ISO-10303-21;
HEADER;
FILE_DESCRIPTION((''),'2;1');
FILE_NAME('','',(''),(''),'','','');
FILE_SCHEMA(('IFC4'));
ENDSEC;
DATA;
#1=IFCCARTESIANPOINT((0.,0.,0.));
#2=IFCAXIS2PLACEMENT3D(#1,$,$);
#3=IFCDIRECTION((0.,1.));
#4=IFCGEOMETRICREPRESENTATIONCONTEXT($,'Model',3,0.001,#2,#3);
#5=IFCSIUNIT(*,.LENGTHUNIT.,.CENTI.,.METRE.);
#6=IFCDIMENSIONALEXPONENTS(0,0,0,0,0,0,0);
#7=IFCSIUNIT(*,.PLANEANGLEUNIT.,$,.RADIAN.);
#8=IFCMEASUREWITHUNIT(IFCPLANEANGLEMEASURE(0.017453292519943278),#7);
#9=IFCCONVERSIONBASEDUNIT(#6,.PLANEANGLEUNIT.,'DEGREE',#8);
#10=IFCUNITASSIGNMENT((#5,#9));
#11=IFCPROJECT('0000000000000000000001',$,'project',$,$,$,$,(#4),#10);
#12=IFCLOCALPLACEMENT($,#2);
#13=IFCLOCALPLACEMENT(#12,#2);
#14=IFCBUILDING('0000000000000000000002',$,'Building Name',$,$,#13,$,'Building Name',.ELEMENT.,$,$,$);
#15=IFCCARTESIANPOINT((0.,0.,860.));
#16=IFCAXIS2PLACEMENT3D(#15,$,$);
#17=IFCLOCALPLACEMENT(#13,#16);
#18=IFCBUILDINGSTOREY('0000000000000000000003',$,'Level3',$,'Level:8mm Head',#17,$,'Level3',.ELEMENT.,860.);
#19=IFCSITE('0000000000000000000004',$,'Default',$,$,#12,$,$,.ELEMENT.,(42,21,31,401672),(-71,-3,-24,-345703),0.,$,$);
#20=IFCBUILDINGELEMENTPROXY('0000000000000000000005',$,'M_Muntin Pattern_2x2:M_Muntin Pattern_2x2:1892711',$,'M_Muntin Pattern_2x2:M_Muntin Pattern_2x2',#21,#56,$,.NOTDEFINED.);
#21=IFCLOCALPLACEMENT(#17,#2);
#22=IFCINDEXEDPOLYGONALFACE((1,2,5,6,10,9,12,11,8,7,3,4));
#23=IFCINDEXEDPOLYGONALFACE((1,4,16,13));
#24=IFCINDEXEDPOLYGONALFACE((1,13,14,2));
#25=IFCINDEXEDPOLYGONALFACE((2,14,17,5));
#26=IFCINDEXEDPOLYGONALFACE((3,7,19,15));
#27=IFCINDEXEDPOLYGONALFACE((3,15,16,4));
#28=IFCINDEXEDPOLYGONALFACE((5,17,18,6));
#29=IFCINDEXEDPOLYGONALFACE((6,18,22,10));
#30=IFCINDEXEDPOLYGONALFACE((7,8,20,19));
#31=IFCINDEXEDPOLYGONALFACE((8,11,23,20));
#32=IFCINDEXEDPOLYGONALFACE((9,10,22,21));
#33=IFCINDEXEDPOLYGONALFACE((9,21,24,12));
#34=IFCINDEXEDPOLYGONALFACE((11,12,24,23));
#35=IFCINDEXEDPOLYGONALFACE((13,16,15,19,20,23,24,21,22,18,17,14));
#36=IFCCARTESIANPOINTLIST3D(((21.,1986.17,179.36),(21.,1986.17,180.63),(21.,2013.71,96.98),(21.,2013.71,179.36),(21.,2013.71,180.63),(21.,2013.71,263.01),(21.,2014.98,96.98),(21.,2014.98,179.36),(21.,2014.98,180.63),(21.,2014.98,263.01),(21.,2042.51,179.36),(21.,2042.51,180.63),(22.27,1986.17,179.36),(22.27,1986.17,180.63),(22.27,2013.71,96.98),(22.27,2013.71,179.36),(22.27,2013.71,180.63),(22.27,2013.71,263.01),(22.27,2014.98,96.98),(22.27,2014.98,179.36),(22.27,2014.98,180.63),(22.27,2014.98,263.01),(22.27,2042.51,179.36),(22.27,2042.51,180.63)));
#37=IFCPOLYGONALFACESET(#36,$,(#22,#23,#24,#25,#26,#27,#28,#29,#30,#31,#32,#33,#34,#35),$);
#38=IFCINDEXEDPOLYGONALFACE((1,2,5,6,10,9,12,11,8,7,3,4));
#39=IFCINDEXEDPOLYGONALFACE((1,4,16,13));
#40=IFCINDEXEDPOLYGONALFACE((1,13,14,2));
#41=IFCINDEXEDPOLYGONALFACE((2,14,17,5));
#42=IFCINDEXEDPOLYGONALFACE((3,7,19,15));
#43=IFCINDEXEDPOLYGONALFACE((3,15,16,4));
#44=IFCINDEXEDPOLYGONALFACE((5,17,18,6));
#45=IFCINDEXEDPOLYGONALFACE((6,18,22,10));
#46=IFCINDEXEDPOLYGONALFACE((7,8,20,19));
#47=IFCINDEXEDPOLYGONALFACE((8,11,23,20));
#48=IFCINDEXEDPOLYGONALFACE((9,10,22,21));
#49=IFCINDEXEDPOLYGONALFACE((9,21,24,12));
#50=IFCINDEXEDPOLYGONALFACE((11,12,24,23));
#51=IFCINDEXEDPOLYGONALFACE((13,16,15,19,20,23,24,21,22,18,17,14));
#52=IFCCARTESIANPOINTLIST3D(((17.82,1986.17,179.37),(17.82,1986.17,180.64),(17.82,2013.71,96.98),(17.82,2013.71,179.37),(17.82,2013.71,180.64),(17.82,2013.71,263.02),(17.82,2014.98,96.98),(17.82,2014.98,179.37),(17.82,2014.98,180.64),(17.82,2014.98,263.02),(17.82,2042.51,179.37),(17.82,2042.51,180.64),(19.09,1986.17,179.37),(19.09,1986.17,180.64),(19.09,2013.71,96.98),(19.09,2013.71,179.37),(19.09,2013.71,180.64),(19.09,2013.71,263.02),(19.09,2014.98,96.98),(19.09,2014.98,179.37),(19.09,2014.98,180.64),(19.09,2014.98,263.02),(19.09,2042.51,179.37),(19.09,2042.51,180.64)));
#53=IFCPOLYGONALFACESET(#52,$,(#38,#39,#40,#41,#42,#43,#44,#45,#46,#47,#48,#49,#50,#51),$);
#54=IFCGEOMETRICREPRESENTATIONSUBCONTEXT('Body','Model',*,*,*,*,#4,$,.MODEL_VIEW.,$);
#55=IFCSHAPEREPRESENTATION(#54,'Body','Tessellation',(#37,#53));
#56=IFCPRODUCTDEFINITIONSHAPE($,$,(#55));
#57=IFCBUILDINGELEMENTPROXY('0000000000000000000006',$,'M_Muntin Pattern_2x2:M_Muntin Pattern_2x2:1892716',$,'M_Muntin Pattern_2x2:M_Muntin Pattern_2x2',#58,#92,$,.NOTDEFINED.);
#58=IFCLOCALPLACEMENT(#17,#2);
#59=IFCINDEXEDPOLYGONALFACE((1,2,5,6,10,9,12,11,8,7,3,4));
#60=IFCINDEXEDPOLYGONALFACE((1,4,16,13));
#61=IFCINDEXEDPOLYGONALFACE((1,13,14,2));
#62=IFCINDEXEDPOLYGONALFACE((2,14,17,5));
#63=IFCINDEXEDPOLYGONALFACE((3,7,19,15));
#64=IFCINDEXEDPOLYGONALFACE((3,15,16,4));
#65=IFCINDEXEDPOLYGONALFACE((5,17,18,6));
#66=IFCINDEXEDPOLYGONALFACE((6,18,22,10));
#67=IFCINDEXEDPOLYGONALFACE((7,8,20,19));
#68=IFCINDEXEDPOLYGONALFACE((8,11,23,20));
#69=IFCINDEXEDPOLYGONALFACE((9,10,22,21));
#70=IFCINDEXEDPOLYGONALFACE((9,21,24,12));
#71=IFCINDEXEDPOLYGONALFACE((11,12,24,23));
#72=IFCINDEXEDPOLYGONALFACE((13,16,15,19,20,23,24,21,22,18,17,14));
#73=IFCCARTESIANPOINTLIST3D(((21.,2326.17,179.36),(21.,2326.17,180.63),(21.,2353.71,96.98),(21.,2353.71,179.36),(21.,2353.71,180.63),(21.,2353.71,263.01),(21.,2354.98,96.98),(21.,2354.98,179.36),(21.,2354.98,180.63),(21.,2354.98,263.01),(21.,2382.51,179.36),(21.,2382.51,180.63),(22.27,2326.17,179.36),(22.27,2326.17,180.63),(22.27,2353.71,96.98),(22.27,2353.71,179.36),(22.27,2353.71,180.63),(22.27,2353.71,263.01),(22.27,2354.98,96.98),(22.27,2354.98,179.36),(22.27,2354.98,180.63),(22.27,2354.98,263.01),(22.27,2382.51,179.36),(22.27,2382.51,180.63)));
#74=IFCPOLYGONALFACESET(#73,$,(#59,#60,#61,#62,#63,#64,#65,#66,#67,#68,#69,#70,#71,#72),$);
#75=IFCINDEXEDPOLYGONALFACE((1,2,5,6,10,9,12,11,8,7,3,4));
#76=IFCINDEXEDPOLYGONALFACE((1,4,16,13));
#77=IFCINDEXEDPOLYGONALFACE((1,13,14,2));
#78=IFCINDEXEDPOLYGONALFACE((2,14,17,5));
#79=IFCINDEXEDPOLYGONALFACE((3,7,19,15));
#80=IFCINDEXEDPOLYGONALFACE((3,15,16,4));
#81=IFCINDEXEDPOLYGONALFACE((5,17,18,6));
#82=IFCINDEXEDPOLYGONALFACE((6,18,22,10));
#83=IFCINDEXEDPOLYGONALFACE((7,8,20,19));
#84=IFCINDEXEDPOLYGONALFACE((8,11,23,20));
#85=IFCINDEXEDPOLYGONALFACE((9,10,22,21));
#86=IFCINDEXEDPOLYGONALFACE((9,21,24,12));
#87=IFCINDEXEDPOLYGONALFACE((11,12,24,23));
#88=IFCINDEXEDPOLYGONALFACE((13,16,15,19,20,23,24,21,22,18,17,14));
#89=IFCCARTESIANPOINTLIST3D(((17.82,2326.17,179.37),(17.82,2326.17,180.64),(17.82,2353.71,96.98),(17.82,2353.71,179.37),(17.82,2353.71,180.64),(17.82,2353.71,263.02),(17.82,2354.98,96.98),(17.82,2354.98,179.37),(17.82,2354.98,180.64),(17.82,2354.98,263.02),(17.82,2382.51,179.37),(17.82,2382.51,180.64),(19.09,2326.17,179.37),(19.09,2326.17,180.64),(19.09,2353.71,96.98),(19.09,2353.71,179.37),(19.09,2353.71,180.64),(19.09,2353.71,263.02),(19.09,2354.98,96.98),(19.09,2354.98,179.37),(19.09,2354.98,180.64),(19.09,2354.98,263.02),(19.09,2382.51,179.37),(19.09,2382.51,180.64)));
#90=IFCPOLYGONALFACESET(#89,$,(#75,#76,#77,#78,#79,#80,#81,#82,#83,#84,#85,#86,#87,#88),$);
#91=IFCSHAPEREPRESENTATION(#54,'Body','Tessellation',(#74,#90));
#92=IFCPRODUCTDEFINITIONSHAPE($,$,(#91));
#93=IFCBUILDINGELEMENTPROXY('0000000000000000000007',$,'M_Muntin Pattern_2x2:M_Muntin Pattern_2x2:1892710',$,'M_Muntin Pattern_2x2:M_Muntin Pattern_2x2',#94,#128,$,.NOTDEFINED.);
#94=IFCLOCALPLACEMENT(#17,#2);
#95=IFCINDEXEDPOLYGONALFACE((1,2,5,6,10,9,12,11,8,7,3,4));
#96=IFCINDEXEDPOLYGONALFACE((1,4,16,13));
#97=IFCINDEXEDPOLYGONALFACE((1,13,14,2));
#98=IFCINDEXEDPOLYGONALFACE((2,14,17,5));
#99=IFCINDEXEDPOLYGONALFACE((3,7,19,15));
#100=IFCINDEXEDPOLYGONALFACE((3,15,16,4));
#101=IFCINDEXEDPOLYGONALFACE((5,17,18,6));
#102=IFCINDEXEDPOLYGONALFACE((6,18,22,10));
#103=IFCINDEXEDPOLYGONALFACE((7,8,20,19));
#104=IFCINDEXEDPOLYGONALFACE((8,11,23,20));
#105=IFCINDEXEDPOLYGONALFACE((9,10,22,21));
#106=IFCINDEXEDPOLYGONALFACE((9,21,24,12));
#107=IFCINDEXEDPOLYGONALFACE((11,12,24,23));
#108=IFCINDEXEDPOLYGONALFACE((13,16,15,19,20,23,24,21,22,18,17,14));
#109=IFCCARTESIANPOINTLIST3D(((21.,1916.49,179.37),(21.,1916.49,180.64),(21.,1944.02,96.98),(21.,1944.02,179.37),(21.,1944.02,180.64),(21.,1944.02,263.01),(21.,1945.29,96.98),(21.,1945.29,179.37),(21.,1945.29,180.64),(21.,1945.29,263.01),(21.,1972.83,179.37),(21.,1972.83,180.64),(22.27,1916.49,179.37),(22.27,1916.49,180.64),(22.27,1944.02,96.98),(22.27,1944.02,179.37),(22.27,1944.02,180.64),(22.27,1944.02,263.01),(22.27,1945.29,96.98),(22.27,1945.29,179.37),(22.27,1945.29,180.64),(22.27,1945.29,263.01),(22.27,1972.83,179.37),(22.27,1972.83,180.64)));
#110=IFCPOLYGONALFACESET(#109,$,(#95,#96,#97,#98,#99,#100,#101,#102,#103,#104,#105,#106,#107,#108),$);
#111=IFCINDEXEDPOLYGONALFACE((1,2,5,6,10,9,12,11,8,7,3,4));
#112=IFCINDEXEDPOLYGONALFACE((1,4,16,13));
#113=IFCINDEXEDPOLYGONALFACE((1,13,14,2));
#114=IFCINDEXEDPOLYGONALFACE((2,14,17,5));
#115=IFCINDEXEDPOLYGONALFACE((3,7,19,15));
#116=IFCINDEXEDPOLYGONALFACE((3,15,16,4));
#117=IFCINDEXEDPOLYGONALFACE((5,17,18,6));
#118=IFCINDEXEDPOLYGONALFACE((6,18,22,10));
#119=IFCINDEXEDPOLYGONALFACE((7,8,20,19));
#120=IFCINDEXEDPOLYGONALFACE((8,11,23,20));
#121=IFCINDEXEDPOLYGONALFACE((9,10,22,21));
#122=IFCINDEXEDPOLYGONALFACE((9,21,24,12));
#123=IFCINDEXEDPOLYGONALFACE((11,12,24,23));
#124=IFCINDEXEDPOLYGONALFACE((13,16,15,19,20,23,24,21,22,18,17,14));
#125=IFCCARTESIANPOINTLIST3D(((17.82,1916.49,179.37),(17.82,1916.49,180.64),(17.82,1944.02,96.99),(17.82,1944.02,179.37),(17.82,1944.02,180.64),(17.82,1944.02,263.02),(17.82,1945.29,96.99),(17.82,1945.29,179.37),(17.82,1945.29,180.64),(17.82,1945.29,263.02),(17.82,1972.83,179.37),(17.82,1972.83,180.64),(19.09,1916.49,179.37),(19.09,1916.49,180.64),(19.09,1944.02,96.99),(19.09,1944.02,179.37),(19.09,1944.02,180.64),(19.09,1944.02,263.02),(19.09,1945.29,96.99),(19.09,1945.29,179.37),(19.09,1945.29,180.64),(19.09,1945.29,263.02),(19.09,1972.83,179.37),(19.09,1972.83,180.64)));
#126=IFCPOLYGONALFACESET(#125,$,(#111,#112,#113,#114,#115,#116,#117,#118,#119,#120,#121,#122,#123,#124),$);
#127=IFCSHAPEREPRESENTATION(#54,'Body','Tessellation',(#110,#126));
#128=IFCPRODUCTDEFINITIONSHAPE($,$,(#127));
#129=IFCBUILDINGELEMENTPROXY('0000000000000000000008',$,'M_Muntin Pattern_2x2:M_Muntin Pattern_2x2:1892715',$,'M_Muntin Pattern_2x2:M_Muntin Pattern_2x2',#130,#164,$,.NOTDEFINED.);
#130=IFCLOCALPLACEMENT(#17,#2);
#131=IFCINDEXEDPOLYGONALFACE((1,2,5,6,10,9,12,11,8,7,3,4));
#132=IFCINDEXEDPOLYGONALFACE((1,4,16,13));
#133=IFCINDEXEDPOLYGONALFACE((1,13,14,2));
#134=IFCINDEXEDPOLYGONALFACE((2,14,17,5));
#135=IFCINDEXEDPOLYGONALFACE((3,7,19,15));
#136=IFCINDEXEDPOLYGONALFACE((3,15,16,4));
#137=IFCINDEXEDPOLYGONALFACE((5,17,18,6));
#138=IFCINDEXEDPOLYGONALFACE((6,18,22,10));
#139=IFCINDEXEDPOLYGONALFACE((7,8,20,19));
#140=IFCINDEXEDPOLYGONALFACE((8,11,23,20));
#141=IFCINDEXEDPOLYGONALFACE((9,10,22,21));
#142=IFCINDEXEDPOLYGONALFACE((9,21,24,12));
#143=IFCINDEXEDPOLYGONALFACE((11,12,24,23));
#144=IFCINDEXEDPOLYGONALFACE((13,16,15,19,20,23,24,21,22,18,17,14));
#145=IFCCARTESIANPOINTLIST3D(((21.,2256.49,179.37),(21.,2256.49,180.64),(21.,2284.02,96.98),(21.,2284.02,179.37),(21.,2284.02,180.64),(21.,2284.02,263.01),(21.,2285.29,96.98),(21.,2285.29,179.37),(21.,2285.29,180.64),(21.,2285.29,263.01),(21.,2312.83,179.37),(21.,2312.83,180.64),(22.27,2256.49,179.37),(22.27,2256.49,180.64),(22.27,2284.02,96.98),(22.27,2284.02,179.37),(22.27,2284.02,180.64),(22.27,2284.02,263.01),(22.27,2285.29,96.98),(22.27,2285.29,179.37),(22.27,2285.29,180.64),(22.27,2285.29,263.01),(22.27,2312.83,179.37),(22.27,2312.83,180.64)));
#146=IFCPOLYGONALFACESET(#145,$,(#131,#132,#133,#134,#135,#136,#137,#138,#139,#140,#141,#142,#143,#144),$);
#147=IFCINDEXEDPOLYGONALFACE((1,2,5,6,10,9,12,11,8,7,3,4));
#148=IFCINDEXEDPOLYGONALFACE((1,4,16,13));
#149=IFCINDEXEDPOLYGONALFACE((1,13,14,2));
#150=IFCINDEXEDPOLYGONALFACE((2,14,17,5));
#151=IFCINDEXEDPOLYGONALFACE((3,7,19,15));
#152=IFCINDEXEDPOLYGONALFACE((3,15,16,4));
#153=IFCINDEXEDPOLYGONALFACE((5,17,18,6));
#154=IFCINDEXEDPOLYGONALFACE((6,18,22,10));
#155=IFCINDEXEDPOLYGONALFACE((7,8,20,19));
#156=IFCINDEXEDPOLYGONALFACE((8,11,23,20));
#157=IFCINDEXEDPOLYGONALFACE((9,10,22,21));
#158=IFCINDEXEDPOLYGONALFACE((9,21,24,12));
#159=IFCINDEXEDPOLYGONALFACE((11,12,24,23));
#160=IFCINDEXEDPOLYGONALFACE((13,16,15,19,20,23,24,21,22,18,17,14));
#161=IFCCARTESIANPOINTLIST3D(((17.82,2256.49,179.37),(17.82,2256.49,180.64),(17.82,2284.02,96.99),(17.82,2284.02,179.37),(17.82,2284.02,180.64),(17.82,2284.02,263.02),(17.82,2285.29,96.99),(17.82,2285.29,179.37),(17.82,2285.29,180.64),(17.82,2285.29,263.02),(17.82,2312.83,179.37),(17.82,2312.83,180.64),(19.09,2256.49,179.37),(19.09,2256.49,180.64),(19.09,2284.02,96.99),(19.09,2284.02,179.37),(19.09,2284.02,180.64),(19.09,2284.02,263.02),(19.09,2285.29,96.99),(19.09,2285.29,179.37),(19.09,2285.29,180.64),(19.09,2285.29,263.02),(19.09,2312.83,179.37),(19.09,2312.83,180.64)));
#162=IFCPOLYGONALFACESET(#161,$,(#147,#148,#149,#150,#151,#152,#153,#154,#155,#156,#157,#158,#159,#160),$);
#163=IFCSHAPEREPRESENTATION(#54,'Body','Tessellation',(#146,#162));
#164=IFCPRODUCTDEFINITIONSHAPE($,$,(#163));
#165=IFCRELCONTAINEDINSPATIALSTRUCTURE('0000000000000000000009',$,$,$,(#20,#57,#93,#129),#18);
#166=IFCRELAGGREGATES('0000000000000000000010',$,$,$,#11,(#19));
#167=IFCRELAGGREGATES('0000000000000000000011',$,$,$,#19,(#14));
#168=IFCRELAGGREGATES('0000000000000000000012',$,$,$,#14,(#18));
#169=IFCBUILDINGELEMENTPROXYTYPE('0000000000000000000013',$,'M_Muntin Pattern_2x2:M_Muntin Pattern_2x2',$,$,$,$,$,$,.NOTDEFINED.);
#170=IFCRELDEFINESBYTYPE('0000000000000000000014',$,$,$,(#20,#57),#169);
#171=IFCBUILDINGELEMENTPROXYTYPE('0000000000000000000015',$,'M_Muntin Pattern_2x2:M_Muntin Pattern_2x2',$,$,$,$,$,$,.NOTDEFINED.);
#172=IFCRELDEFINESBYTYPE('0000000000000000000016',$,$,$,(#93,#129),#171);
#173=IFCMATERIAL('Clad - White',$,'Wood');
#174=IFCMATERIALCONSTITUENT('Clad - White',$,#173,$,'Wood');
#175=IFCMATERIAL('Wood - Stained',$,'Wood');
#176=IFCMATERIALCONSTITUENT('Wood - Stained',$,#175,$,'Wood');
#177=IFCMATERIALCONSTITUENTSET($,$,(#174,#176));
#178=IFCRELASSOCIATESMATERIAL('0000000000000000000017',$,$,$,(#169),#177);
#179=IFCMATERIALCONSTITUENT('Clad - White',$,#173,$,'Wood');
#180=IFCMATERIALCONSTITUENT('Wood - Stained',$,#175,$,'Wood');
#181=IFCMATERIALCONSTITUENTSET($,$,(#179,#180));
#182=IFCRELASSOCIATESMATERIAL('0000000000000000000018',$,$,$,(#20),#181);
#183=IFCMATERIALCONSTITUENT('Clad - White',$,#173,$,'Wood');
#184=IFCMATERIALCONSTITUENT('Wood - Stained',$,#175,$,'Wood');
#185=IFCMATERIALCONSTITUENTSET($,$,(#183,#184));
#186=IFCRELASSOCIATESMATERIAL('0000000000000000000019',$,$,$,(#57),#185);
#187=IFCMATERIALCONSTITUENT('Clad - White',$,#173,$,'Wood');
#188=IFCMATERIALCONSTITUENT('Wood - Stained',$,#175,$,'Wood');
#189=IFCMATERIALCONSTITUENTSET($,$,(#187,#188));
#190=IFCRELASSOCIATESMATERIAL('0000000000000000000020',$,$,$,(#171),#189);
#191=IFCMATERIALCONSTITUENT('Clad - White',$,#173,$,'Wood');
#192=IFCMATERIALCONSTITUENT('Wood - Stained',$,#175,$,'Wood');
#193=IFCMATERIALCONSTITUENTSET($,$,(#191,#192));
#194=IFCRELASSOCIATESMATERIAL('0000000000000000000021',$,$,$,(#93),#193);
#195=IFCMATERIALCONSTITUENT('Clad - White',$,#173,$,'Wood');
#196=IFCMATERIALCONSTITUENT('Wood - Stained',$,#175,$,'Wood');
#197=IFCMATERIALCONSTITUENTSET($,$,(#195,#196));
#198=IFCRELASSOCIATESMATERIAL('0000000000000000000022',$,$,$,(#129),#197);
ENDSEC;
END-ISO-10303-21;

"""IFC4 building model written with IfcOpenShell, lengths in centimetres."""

from ifc_helpers import new_model, entity, si_unit, converted_unit, direction, frame, origin, place, context, subcontext, project, spatial, indexed_curve, outline, extrude, source, transform, mapped, material, constituent, constituent_set, type_object, type_shapes, element, save


model = new_model("IFC4")

# Units and contexts
model_context = context("Model", 3, precision=0.001, world=origin(), true_north=direction((0.0, 1.0)))
body_context = subcontext(model_context, "Body", "Model", "MODEL_VIEW")
ifc_project = project(units=[si_unit("LENGTHUNIT", "METRE", prefix="CENTI"), converted_unit("PLANEANGLEUNIT", "DEGREE", entity("IfcPlaneAngleMeasure", 0.017453292519943278), si_unit("PLANEANGLEUNIT", "RADIAN"), dimensions=[0, 0, 0, 0, 0, 0, 0])], contexts=[model_context])

# Site, building, storey
site_placement = place(None, origin())
site = spatial("IfcSite", under=ifc_project, at=site_placement, Name="Default", CompositionType="ELEMENT", RefLatitude=(42, 21, 31, 401672), RefLongitude=(-71, -3, -24, -345703), RefElevation=0.0)
building_placement = place(site_placement, origin())
building = spatial("IfcBuilding", under=site, at=building_placement, Name="Building Name", LongName="Building Name", CompositionType="ELEMENT")
storey_placement = place(building_placement, frame((0.0, 0.0, 860.0)))
storey = spatial("IfcBuildingStorey", under=building, at=storey_placement, Name="Level3", ObjectType="Level:8mm Head", LongName="Level3", CompositionType="ELEMENT", Elevation=860.0)

# Shared definitions
ifc_material_1 = material(Name="Clad - White", Category="Wood")
ifc_material_2 = material(Name="Wood - Stained", Category="Wood")

# Building element proxies
ifc_constituent_1 = constituent(ifc_material_1, Name="Clad - White", Category="Wood")
ifc_constituent_2 = constituent(ifc_material_2, Name="Wood - Stained", Category="Wood")
ifc_constituent_set_1 = constituent_set(constituents=[ifc_constituent_1, ifc_constituent_2])
ifc_constituent_3 = constituent(ifc_material_1, Name="Clad - White", Category="Wood")
ifc_constituent_4 = constituent(ifc_material_2, Name="Wood - Stained", Category="Wood")
ifc_constituent_set_2 = constituent_set(constituents=[ifc_constituent_3, ifc_constituent_4])
building_element_proxy_type_1 = type_object("IfcBuildingElementProxyType", Name="M_Muntin Pattern_2x2:M_Muntin Pattern_2x2", PredefinedType="NOTDEFINED", material=ifc_constituent_set_2)
shared_shape_1 = source(origin(), body_context, "Body", "SweptSolid", [
    extrude(outline(indexed_curve([(0.64, -0.64), (83.01, -0.64), (83.01, 0.63), (0.64, 0.63), (0.64, 28.17), (-0.63, 28.17), (-0.63, 0.63), (-83.02, 0.63), (-83.02, -0.64), (-0.63, -0.64), (-0.63, -28.17), (0.64, -28.17), (0.64, -0.64)], self_intersect=False)), frame((0.0, 0.95, 83.01), z_axis=(0.0, 1.0, 0.0), x_axis=(0.0, 0.0, 1.0)), (0.0, 0.0, 1.0), 1.27),
    extrude(outline(indexed_curve([(0.64, -0.64), (83.02, -0.64), (83.02, 0.63), (0.64, 0.63), (0.64, 28.17), (-0.63, 28.17), (-0.63, 0.63), (-83.02, 0.63), (-83.02, -0.64), (-0.63, -0.64), (-0.63, -28.17), (0.64, -28.17), (0.64, -0.64)], self_intersect=False)), frame((0.0, -2.22, 83.02), z_axis=(0.0, 1.0, 0.0), x_axis=(0.0, 0.0, 1.0)), (0.0, 0.0, 1.0), 1.27),
])
type_shapes(building_element_proxy_type_1, [shared_shape_1])
proxy_1_placement = place(storey_placement, frame((20.05, 2014.34, 96.98), z_axis=(0.0, 0.0, 1.0), x_axis=(0.0, -1.0, 0.0)))
element("IfcBuildingElementProxy", 1, at=proxy_1_placement, inside=storey, type_object=building_element_proxy_type_1, material=ifc_constituent_set_1, Name="M_Muntin Pattern_2x2:M_Muntin Pattern_2x2:1892711", ObjectType="M_Muntin Pattern_2x2:M_Muntin Pattern_2x2", PredefinedType="NOTDEFINED", context=body_context, shape_type="MappedRepresentation", body=[
    mapped(shared_shape_1, transform((0.0, 0.0, 0.0), scale=1.0)),
])
ifc_constituent_5 = constituent(ifc_material_1, Name="Clad - White", Category="Wood")
ifc_constituent_6 = constituent(ifc_material_2, Name="Wood - Stained", Category="Wood")
ifc_constituent_set_3 = constituent_set(constituents=[ifc_constituent_5, ifc_constituent_6])
proxy_2_placement = place(storey_placement, frame((20.05, 2354.34, 96.98), z_axis=(0.0, 0.0, 1.0), x_axis=(0.0, -1.0, 0.0)))
element("IfcBuildingElementProxy", 2, at=proxy_2_placement, inside=storey, type_object=building_element_proxy_type_1, material=ifc_constituent_set_3, Name="M_Muntin Pattern_2x2:M_Muntin Pattern_2x2:1892716", ObjectType="M_Muntin Pattern_2x2:M_Muntin Pattern_2x2", PredefinedType="NOTDEFINED", context=body_context, shape_type="MappedRepresentation", body=[
    mapped(shared_shape_1, transform((0.0, 0.0, 0.0), scale=1.0)),
])
ifc_constituent_7 = constituent(ifc_material_1, Name="Clad - White", Category="Wood")
ifc_constituent_8 = constituent(ifc_material_2, Name="Wood - Stained", Category="Wood")
ifc_constituent_set_4 = constituent_set(constituents=[ifc_constituent_7, ifc_constituent_8])
ifc_constituent_9 = constituent(ifc_material_1, Name="Clad - White", Category="Wood")
ifc_constituent_10 = constituent(ifc_material_2, Name="Wood - Stained", Category="Wood")
ifc_constituent_set_5 = constituent_set(constituents=[ifc_constituent_9, ifc_constituent_10])
building_element_proxy_type_2 = type_object("IfcBuildingElementProxyType", Name="M_Muntin Pattern_2x2:M_Muntin Pattern_2x2", PredefinedType="NOTDEFINED", material=ifc_constituent_set_5)
shared_shape_2 = source(origin(), body_context, "Body", "SweptSolid", [
    extrude(outline(indexed_curve([(0.64, -0.64), (83.01, -0.64), (83.01, 0.63), (0.64, 0.63), (0.64, 28.17), (-0.63, 28.17), (-0.63, 0.63), (-83.02, 0.63), (-83.02, -0.64), (-0.63, -0.64), (-0.63, -28.17), (0.64, -28.17), (0.64, -0.64)], self_intersect=False)), frame((0.0, -2.22, 83.01), z_axis=(0.0, 1.0, 0.0), x_axis=(0.0, 0.0, 1.0)), (0.0, 0.0, 1.0), 1.27),
    extrude(outline(indexed_curve([(0.64, -0.64), (83.02, -0.64), (83.02, 0.63), (0.64, 0.63), (0.64, 28.17), (-0.63, 28.17), (-0.63, 0.63), (-83.02, 0.63), (-83.02, -0.64), (-0.63, -0.64), (-0.63, -28.17), (0.64, -28.17), (0.64, -0.64)], self_intersect=False)), frame((0.0, 0.95, 83.02), z_axis=(0.0, 1.0, 0.0), x_axis=(0.0, 0.0, 1.0)), (0.0, 0.0, 1.0), 1.27),
])
type_shapes(building_element_proxy_type_2, [shared_shape_2])
proxy_3_placement = place(storey_placement, frame((20.05, 1944.66, 96.99), z_axis=(0.0, 0.0, 1.0), x_axis=(0.0, 1.0, 0.0)))
element("IfcBuildingElementProxy", 3, at=proxy_3_placement, inside=storey, type_object=building_element_proxy_type_2, material=ifc_constituent_set_4, Name="M_Muntin Pattern_2x2:M_Muntin Pattern_2x2:1892710", ObjectType="M_Muntin Pattern_2x2:M_Muntin Pattern_2x2", PredefinedType="NOTDEFINED", context=body_context, shape_type="MappedRepresentation", body=[
    mapped(shared_shape_2, transform((0.0, 0.0, 0.0), scale=1.0)),
])
ifc_constituent_11 = constituent(ifc_material_1, Name="Clad - White", Category="Wood")
ifc_constituent_12 = constituent(ifc_material_2, Name="Wood - Stained", Category="Wood")
ifc_constituent_set_6 = constituent_set(constituents=[ifc_constituent_11, ifc_constituent_12])
proxy_4_placement = place(storey_placement, frame((20.05, 2284.66, 96.99), z_axis=(0.0, 0.0, 1.0), x_axis=(0.0, 1.0, 0.0)))
element("IfcBuildingElementProxy", 4, at=proxy_4_placement, inside=storey, type_object=building_element_proxy_type_2, material=ifc_constituent_set_6, Name="M_Muntin Pattern_2x2:M_Muntin Pattern_2x2:1892715", ObjectType="M_Muntin Pattern_2x2:M_Muntin Pattern_2x2", PredefinedType="NOTDEFINED", context=body_context, shape_type="MappedRepresentation", body=[
    mapped(shared_shape_2, transform((0.0, 0.0, 0.0), scale=1.0)),
])

save(model, "model.ifc")
